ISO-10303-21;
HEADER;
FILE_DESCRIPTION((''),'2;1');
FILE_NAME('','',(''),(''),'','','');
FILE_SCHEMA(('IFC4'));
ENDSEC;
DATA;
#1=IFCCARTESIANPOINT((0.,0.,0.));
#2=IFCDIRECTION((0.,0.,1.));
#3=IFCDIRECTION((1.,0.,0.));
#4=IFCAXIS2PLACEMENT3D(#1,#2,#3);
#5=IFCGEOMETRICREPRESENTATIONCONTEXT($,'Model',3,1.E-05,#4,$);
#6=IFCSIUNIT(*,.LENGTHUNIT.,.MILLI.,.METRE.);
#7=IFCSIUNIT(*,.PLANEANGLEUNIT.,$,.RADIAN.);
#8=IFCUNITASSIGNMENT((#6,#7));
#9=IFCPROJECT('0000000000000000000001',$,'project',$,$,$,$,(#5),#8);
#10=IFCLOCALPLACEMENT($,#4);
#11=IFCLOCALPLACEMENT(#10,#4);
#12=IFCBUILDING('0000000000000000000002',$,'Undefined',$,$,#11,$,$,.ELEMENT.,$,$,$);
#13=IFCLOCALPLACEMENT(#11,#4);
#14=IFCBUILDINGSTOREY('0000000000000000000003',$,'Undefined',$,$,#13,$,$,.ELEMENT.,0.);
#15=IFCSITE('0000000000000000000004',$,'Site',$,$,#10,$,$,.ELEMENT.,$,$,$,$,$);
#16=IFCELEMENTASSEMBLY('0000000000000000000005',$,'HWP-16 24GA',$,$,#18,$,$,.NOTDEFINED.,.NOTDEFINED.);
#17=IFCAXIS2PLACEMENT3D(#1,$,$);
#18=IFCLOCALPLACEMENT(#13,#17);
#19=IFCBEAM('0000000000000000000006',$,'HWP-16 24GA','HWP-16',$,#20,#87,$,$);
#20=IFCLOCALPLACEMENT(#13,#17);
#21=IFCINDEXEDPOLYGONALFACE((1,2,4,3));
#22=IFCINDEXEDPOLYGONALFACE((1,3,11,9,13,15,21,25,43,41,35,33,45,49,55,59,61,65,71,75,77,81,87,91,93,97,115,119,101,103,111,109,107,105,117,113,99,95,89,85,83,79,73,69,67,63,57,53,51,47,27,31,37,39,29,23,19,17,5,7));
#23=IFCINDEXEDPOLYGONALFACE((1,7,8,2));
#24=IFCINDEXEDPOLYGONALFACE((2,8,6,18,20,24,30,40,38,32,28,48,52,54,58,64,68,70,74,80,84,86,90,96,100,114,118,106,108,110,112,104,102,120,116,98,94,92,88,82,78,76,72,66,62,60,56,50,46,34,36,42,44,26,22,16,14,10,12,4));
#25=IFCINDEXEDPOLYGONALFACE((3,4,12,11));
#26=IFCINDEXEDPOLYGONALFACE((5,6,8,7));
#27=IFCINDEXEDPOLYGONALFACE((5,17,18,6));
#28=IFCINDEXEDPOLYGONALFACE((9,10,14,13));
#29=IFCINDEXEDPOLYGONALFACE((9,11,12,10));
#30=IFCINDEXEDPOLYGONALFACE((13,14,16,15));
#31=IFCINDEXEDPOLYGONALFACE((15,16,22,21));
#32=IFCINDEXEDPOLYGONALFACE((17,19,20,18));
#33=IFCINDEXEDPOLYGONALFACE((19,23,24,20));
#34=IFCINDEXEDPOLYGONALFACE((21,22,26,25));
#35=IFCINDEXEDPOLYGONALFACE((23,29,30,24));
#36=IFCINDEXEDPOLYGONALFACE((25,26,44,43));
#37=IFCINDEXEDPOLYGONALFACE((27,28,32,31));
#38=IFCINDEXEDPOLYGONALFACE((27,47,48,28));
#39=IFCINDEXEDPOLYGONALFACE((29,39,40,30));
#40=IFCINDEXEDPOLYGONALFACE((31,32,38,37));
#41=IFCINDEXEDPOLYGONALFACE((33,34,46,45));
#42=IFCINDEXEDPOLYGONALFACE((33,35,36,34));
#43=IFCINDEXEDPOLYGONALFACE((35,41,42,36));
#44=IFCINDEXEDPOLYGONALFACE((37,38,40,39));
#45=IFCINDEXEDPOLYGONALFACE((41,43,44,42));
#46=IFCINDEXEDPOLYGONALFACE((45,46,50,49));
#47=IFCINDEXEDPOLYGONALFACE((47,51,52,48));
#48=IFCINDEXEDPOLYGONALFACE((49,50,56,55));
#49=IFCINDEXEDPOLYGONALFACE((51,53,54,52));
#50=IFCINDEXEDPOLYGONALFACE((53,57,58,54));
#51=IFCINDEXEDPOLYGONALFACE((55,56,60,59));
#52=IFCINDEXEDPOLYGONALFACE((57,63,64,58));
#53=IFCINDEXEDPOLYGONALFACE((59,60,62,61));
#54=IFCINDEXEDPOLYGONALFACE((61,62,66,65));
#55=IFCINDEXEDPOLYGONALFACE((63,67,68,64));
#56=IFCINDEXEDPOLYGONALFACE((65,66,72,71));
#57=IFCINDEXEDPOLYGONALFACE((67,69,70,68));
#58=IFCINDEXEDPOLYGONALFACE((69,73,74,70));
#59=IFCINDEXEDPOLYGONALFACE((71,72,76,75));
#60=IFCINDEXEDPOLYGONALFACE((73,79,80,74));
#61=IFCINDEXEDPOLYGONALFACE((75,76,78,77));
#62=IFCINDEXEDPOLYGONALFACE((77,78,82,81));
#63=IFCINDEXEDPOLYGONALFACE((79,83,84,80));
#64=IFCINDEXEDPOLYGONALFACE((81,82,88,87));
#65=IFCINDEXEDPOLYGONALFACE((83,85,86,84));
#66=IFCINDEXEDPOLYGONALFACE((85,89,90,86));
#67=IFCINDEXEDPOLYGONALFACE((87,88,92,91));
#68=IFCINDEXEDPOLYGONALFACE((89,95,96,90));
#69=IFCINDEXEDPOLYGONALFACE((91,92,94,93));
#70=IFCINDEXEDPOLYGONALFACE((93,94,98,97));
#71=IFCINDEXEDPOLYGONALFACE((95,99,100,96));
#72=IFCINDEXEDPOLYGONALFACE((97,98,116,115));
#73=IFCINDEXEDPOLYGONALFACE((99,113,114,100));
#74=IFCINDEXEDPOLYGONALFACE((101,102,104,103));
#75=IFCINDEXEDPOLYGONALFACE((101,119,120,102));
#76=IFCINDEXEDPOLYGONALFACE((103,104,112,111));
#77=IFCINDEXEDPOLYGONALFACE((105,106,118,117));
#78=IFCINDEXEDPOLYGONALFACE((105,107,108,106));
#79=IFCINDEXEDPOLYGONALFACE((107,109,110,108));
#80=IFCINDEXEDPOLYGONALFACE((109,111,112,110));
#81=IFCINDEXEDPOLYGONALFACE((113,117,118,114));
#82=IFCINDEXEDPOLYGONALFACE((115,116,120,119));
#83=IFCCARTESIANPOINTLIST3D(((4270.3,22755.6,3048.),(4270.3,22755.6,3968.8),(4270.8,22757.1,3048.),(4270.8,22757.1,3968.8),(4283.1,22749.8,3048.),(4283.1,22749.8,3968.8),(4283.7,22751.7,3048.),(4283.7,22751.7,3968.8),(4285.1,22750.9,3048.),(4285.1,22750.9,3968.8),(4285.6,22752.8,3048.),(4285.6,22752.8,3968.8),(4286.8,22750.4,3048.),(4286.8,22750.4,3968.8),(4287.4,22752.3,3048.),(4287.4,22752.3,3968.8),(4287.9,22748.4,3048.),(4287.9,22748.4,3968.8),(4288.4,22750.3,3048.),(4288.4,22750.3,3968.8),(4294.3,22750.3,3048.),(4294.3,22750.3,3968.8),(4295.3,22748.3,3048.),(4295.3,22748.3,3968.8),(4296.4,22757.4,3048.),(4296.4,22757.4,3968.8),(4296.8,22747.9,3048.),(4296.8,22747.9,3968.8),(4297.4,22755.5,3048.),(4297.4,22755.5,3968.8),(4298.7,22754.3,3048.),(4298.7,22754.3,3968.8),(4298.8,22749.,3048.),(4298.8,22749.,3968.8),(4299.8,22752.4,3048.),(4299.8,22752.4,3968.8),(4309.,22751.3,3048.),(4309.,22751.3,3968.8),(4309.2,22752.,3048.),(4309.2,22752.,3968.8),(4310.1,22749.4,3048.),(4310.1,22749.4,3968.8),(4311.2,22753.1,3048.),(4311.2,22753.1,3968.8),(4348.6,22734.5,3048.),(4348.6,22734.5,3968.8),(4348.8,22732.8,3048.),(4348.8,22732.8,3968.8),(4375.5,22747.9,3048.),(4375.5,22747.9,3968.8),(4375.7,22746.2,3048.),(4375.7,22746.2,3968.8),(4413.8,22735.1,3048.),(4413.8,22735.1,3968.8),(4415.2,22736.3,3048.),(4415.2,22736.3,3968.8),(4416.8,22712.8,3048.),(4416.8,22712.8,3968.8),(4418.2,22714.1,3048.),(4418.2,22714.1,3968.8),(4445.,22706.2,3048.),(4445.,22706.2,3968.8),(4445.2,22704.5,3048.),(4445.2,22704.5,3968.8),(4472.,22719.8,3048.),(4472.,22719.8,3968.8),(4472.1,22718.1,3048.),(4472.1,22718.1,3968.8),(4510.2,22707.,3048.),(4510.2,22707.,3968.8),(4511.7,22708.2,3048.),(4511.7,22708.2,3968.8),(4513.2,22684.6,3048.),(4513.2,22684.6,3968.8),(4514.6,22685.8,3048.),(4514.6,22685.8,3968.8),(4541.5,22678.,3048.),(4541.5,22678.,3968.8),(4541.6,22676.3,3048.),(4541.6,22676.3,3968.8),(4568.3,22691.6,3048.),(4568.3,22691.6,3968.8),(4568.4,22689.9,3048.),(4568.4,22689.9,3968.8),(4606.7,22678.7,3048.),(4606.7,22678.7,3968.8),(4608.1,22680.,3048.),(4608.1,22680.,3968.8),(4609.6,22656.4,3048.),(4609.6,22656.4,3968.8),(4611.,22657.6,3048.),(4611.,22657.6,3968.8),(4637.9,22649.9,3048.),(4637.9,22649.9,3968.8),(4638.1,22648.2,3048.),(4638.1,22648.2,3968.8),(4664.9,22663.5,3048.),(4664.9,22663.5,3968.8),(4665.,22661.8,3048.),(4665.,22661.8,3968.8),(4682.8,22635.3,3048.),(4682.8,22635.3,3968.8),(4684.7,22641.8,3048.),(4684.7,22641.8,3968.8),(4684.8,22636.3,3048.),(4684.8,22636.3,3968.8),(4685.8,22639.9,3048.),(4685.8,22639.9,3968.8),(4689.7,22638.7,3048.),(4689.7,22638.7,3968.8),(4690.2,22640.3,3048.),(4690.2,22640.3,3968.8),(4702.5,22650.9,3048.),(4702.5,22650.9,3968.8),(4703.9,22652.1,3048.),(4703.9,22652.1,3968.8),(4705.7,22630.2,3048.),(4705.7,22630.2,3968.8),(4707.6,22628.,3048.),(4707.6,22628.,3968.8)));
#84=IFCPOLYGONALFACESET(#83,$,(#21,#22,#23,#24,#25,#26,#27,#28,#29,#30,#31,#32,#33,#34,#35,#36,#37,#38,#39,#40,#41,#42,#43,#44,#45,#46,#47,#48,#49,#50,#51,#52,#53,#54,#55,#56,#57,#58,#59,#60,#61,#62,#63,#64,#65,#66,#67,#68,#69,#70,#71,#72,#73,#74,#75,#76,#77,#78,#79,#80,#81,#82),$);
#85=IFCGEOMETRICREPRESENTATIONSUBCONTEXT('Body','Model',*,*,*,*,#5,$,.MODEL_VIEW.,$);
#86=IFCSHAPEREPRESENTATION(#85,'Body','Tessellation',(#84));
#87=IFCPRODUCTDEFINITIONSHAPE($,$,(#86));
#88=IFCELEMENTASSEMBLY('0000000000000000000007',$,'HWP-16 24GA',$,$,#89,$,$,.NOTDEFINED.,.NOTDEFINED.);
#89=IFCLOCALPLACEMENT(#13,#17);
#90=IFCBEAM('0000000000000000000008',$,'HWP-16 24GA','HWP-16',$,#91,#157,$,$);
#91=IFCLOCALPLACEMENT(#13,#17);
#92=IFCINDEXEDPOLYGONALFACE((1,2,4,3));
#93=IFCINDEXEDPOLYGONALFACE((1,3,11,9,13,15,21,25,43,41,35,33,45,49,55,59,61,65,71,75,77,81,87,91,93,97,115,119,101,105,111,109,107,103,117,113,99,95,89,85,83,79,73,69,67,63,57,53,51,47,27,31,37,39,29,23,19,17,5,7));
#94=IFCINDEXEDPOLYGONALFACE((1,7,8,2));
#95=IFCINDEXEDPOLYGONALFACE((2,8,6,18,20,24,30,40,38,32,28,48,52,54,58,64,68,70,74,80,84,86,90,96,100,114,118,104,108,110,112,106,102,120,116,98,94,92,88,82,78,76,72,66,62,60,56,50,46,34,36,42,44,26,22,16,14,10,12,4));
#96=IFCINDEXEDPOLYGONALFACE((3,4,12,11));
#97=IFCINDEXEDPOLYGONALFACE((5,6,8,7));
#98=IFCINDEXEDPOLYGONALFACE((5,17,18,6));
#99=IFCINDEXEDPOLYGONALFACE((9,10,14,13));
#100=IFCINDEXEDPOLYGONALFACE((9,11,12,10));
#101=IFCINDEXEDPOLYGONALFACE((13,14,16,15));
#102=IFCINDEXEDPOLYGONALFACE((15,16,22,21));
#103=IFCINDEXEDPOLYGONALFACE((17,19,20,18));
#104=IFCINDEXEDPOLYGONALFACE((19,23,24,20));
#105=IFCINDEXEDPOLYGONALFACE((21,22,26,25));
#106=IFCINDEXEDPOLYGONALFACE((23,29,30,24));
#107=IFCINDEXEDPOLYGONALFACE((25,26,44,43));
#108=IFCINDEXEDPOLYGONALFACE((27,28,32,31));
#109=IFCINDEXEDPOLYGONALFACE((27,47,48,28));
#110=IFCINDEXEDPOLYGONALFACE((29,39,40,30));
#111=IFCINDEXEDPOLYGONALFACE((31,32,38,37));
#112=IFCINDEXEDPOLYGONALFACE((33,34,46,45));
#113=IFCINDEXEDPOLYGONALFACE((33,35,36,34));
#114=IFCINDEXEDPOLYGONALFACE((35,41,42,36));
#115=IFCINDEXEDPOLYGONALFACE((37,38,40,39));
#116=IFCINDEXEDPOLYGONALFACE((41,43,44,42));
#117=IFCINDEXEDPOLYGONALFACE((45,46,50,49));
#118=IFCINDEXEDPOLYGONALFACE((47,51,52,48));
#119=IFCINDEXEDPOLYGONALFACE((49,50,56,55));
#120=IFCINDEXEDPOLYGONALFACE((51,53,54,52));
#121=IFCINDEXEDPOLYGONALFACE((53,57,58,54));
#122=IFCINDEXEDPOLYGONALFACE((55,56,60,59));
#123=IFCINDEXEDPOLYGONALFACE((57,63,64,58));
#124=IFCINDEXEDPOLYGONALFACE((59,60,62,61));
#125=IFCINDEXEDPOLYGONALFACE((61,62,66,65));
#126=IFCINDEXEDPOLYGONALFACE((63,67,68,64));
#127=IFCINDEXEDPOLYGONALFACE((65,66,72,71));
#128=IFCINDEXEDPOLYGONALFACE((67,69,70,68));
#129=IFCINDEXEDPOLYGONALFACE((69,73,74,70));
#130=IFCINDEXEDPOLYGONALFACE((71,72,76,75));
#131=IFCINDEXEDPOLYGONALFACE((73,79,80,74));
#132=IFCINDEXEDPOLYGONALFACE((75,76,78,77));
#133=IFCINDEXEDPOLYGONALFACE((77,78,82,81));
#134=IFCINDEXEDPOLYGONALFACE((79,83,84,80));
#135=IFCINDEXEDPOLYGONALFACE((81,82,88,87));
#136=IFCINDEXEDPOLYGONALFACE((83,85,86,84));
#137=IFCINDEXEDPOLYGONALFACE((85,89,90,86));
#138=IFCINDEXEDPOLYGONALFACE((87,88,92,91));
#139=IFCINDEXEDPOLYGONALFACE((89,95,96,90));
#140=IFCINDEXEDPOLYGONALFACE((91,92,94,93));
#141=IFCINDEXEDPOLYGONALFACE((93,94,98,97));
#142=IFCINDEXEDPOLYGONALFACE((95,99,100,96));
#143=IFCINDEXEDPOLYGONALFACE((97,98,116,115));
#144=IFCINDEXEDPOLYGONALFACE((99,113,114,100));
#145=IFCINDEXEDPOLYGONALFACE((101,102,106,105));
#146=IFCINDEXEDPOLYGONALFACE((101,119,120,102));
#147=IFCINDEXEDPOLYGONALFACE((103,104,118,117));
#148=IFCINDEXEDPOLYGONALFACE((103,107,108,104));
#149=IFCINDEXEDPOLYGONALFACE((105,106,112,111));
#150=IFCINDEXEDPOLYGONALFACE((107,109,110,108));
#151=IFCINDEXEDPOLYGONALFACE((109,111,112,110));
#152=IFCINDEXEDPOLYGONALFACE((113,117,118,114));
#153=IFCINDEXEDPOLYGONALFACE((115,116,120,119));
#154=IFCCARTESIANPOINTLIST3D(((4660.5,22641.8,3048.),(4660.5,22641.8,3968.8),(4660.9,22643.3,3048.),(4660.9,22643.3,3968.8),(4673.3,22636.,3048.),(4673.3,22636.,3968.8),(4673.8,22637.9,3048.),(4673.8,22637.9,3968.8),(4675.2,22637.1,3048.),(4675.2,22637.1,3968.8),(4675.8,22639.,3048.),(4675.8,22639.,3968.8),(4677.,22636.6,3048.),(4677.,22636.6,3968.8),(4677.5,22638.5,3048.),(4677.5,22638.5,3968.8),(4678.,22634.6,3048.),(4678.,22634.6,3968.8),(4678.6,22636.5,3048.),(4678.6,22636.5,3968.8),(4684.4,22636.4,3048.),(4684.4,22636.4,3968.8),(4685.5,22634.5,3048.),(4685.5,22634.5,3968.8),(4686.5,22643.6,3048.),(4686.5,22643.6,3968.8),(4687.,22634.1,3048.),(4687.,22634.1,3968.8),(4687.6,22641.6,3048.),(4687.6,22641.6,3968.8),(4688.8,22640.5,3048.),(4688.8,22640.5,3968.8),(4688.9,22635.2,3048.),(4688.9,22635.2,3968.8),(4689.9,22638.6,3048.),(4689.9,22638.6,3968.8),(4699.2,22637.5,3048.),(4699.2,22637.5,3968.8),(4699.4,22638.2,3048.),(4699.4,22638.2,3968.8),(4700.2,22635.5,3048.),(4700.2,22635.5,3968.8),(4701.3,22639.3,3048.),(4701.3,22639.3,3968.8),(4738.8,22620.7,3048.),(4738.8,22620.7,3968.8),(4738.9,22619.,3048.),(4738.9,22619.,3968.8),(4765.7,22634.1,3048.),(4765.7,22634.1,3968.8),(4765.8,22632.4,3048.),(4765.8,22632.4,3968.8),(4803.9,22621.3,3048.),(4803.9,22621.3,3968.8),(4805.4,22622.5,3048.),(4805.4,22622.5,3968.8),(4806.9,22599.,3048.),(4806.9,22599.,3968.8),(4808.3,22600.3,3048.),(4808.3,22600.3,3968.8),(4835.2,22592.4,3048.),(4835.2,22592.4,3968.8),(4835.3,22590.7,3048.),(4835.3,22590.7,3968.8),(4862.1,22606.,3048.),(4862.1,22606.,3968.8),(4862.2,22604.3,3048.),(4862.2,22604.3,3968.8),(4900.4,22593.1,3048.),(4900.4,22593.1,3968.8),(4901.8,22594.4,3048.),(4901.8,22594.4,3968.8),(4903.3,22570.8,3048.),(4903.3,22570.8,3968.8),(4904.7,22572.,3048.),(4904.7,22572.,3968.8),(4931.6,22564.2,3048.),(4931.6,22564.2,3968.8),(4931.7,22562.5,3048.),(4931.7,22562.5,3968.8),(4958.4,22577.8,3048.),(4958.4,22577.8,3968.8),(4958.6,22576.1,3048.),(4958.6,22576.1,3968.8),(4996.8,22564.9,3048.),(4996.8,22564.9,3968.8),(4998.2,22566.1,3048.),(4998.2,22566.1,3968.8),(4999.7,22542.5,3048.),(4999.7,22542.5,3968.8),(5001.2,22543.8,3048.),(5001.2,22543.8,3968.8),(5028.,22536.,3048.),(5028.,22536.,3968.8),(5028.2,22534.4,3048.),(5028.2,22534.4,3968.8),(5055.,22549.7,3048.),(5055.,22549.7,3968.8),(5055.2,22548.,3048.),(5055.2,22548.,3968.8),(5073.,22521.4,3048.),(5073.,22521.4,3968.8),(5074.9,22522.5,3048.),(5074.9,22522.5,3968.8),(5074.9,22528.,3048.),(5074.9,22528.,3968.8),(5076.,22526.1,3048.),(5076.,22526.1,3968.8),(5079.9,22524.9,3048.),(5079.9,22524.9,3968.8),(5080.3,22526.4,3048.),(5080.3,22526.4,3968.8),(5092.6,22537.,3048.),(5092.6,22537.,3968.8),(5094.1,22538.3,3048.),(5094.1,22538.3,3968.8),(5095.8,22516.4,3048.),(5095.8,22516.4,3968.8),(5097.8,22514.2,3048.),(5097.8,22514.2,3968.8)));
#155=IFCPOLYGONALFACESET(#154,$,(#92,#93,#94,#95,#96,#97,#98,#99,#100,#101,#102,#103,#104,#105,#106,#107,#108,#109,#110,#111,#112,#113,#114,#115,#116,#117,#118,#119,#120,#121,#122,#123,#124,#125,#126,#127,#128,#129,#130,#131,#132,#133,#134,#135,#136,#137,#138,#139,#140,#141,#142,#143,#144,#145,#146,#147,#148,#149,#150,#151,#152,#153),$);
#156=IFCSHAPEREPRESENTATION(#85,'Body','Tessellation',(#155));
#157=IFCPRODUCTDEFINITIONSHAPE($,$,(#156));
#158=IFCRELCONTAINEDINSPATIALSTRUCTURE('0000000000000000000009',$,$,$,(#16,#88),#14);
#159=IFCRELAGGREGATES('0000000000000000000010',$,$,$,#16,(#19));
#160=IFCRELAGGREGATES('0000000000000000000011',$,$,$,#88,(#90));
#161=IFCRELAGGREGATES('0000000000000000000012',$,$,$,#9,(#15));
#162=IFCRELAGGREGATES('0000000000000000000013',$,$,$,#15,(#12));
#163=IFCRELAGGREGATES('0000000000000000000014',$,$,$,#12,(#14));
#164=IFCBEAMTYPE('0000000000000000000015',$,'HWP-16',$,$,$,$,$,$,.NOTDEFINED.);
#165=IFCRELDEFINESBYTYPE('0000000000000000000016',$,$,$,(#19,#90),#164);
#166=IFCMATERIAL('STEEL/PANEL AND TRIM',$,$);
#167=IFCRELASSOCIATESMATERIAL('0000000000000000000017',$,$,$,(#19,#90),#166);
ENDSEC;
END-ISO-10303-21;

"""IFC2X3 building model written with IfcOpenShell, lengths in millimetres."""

from ifc_helpers import new_model, si_unit, frame, origin_with_axes, place, context, subcontext, project, spatial, polyline, outline, extrude, boolean, material, type_object, element, aggregate, save


model = new_model("IFC2X3")

# Units and contexts
model_context = context("Model", 3, precision=1e-05, world=origin_with_axes())
body_context = subcontext(model_context, "Body", "Model", "MODEL_VIEW")
ifc_project = project(units=[si_unit("LENGTHUNIT", "METRE", prefix="MILLI"), si_unit("PLANEANGLEUNIT", "RADIAN")], contexts=[model_context])

# Site, building, storey
site_placement = place(None, origin_with_axes())
site = spatial("IfcSite", under=ifc_project, at=site_placement, Name="Site", CompositionType="ELEMENT")
building_placement = place(site_placement, origin_with_axes())
building = spatial("IfcBuilding", under=site, at=building_placement, Name="Undefined", CompositionType="ELEMENT")
storey_placement = place(building_placement, origin_with_axes())
storey = spatial("IfcBuildingStorey", under=building, at=storey_placement, Name="Undefined", CompositionType="ELEMENT", Elevation=0.0)

# Element assemblies, beams
ifc_material_1 = material(Name="STEEL/PANEL AND TRIM")
beam_type_1 = type_object("IfcBeamType", Name="HWP-16", PredefinedType="NOTDEFINED")
assembly_1_placement = place(storey_placement, origin_with_axes())
assembly_1 = element("IfcElementAssembly", 1, at=assembly_1_placement, inside=storey, Name="HWP-16 24GA", AssemblyPlace="NOTDEFINED", PredefinedType="NOTDEFINED")
beam_1_placement = place(assembly_1_placement, frame((4703.9, 22652.1, 3968.8), z_axis=(-0.280057, -0.959983, 0.0), x_axis=(0.0, 0.0, -1.0)))
beam_1 = element("IfcBeam", 2, at=beam_1_placement, type_object=beam_type_1, material=ifc_material_1, Name="HWP-16 24GA", Description="HWP-16", context=body_context, shape_type="CSG", body=[
    boolean("DIFFERENCE", extrude(outline(polyline([(40.7, 0.0), (0.0, 0.0), (-10.3, 22.1), (15.5, 22.1), (15.5, 15.2), (9.9, 15.2), (9.9, 16.8), (13.9, 16.8), (13.9, 20.5), (-7.8, 20.5), (1.0, 1.6), (40.1, 1.6), (62.1, 22.2), (91.7, 22.3), (100.8, 1.7), (140.6, 1.7), (162.6, 22.2), (192.2, 22.2), (201.3, 1.6), (241.0, 1.6), (263.1, 22.1), (292.7, 22.1), (301.8, 1.6), (341.5, 1.6), (363.5, 22.0), (417.6, 22.0), (417.6, 15.3), (406.9, 15.3), (406.9, 14.6), (419.2, 14.6), (419.2, 22.1), (426.4, 22.1), (426.4, 24.0), (431.3, 24.0), (431.3, 22.1), (445.2, 22.1), (445.2, 20.5), (429.7, 20.5), (429.7, 22.5), (427.9, 22.5), (427.9, 20.5), (420.7, 20.5), (420.7, 13.0), (405.3, 13.0), (405.3, 16.9), (416.0, 16.9), (416.0, 20.4), (364.1, 20.4), (342.1, 0.0), (300.7, 0.0), (291.6, 20.5), (263.7, 20.5), (241.6, 0.0), (200.3, 0.0), (191.2, 20.6), (163.2, 20.6), (141.3, 0.1), (99.8, 0.1), (90.7, 20.7), (62.7, 20.6), (40.7, 0.0)])), frame((1225.5, 0.0, 0.0), z_axis=(-1.0, 0.0, 0.0), x_axis=(0.0, -1.0, 0.0)), (0.0, 0.0, 1.0), 1225.5), extrude(outline(polyline([(0.0, 0.0), (5029.2, 0.0), (5029.2, 609.6), (0.0, 609.6), (0.0, 0.0)])), frame((920.8, 3200.4, -10.0), z_axis=(0.0, 0.0, 1.0), x_axis=(0.0, -1.0, 0.0)), (0.0, 0.0, 1.0), 44.0)),
])
aggregate(assembly_1, [beam_1])
assembly_2_placement = place(storey_placement, origin_with_axes())
assembly_2 = element("IfcElementAssembly", 3, at=assembly_2_placement, inside=storey, Name="HWP-16 24GA", AssemblyPlace="NOTDEFINED", PredefinedType="NOTDEFINED")
beam_2_placement = place(assembly_2_placement, frame((5094.1, 22538.3, 3968.8), z_axis=(-0.280057, -0.959983, 0.0), x_axis=(0.0, 0.0, -1.0)))
beam_2 = element("IfcBeam", 4, at=beam_2_placement, type_object=beam_type_1, material=ifc_material_1, Name="HWP-16 24GA", Description="HWP-16", context=body_context, shape_type="CSG", body=[
    boolean("DIFFERENCE", extrude(outline(polyline([(40.7, 0.0), (0.0, 0.0), (-10.3, 22.1), (15.5, 22.1), (15.5, 15.2), (9.9, 15.2), (9.9, 16.8), (13.9, 16.8), (13.9, 20.5), (-7.8, 20.5), (1.0, 1.6), (40.1, 1.6), (62.1, 22.2), (91.7, 22.3), (100.8, 1.7), (140.6, 1.7), (162.6, 22.2), (192.2, 22.2), (201.3, 1.6), (241.0, 1.6), (263.1, 22.1), (292.7, 22.1), (301.8, 1.6), (341.5, 1.6), (363.5, 22.0), (417.6, 22.0), (417.6, 15.3), (406.9, 15.3), (406.9, 14.6), (419.2, 14.6), (419.2, 22.1), (426.4, 22.1), (426.4, 24.0), (431.3, 24.0), (431.3, 22.1), (445.2, 22.1), (445.2, 20.5), (429.7, 20.5), (429.7, 22.5), (427.9, 22.5), (427.9, 20.5), (420.7, 20.5), (420.7, 13.0), (405.3, 13.0), (405.3, 16.9), (416.0, 16.9), (416.0, 20.4), (364.1, 20.4), (342.1, 0.0), (300.7, 0.0), (291.6, 20.5), (263.7, 20.5), (241.6, 0.0), (200.3, 0.0), (191.2, 20.6), (163.2, 20.6), (141.3, 0.1), (99.8, 0.1), (90.7, 20.7), (62.7, 20.6), (40.7, 0.0)])), frame((1225.5, 0.0, 0.0), z_axis=(-1.0, 0.0, 0.0), x_axis=(0.0, -1.0, 0.0)), (0.0, 0.0, 1.0), 1225.5), extrude(outline(polyline([(0.0, 0.0), (5029.2, 0.0), (5029.2, 609.6), (0.0, 609.6), (0.0, 0.0)])), frame((920.8, 2794.0, -10.0), z_axis=(0.0, 0.0, 1.0), x_axis=(0.0, -1.0, 0.0)), (0.0, 0.0, 1.0), 44.0)),
])
aggregate(assembly_2, [beam_2])

save(model, "model.ifc")
